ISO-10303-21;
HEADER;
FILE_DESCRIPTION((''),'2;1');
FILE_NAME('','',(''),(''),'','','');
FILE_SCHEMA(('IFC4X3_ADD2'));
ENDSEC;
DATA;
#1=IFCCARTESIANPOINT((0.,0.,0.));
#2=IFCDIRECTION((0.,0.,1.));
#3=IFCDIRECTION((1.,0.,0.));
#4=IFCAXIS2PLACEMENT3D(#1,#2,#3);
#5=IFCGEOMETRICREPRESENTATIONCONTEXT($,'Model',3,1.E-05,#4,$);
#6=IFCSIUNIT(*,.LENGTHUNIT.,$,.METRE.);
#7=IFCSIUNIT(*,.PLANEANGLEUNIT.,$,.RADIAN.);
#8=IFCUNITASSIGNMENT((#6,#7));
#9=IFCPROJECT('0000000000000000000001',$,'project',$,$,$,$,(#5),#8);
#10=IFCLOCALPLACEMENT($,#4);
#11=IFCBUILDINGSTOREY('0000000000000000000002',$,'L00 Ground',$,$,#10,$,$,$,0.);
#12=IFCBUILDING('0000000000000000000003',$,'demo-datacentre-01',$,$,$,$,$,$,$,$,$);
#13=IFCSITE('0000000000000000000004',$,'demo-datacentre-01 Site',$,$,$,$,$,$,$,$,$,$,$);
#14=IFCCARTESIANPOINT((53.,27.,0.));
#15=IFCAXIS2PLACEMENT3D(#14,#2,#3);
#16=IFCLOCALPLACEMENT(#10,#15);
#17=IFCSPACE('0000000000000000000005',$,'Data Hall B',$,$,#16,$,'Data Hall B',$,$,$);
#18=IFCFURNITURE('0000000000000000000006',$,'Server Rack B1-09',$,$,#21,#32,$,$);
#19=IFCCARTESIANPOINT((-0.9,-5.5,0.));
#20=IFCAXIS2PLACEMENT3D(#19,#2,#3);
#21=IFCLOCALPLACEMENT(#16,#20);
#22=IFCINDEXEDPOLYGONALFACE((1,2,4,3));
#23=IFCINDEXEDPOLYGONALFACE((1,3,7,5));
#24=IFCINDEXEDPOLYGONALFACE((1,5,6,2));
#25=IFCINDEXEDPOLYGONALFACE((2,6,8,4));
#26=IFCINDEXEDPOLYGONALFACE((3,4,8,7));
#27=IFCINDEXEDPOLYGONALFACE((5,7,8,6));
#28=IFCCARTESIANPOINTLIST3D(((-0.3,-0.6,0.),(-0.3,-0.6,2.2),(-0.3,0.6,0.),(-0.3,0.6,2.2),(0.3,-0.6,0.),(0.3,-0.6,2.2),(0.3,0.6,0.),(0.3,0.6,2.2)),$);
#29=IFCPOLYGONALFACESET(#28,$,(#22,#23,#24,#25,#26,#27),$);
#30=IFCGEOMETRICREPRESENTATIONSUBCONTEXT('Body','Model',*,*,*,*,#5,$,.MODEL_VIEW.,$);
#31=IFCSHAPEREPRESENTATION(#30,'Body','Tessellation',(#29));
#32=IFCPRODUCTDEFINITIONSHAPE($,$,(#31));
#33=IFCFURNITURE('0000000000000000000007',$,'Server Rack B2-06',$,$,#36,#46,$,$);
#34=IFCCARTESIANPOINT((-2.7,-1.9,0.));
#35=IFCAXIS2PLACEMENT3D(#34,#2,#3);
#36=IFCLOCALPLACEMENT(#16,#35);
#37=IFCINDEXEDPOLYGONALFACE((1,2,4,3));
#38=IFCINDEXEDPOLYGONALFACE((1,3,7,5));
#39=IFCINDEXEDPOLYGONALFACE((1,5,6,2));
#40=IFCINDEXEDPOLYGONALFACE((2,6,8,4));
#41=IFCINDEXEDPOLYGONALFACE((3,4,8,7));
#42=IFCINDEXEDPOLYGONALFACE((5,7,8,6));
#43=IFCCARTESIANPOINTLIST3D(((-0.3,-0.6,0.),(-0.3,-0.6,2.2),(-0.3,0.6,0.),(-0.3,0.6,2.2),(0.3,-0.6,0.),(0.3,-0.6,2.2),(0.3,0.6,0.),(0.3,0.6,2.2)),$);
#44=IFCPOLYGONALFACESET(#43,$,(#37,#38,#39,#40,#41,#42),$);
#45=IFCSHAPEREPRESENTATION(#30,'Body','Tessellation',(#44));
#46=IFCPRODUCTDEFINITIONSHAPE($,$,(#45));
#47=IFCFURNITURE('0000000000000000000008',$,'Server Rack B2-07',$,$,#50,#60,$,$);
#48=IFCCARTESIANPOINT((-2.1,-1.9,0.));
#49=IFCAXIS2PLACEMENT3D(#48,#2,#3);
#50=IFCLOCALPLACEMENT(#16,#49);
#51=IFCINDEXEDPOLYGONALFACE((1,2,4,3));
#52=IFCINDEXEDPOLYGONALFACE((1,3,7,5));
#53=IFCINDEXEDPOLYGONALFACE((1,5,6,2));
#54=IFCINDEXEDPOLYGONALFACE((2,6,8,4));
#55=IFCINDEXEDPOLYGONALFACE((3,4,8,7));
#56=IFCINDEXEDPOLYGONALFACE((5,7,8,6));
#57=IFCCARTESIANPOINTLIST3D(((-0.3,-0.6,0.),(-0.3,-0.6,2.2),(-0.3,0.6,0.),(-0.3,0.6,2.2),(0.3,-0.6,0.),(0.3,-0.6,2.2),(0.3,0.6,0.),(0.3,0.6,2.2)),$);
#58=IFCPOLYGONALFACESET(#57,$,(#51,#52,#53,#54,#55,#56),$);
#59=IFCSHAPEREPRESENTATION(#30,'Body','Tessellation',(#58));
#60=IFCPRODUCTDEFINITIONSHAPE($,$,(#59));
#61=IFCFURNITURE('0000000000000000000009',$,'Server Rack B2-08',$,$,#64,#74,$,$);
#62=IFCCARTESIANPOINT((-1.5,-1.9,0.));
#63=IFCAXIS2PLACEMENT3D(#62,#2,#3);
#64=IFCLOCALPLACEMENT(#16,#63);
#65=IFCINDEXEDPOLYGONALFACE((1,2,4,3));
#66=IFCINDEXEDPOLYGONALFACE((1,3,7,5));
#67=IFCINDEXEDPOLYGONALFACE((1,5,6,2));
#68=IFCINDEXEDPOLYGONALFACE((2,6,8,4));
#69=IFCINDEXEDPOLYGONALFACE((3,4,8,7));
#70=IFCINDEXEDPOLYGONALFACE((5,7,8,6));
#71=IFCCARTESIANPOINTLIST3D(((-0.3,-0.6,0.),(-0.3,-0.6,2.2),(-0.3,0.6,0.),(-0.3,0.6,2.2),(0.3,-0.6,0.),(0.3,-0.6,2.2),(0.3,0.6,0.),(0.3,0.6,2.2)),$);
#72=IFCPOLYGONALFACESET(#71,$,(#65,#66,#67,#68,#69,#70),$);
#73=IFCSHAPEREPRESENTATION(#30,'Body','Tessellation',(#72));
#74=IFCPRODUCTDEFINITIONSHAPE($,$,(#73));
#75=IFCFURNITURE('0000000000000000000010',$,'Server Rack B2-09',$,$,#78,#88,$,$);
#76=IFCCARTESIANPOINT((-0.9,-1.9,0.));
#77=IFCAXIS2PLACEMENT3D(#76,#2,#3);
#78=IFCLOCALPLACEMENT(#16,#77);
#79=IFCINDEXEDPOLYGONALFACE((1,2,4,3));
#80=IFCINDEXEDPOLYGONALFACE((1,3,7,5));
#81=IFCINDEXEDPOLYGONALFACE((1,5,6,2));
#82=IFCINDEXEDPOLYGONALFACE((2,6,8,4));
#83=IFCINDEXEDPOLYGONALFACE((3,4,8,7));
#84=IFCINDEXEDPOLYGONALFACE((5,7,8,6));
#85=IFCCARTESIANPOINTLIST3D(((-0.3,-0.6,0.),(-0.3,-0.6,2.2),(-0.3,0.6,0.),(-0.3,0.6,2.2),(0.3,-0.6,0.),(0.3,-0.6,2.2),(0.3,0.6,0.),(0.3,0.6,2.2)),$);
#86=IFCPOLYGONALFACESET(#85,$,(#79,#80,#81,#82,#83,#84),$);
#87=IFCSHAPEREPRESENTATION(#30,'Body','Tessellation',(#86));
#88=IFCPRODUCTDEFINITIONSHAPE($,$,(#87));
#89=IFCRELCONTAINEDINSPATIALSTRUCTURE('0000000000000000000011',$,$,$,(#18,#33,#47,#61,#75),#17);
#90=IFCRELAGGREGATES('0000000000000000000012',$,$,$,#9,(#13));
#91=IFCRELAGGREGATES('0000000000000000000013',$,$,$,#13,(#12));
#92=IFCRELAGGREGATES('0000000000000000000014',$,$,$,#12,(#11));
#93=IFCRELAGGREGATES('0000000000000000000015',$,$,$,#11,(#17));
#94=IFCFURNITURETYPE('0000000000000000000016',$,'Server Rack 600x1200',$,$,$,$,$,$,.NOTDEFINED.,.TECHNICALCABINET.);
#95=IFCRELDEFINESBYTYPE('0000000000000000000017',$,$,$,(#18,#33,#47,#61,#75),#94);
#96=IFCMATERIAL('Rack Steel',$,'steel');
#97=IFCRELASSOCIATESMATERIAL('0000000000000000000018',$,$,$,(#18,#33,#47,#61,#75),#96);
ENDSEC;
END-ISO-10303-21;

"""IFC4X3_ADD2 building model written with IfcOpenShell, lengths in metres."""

from ifc_helpers import new_model, si_unit, frame, origin_with_axes, place, context, subcontext, project, spatial, rectangle, extrude, material, type_object, element, save


model = new_model("IFC4X3_ADD2")

# Units and contexts
model_context = context("Model", 3, precision=1e-05, world=origin_with_axes())
body_context = subcontext(model_context, "Body", "Model", "MODEL_VIEW")
ifc_project = project(units=[si_unit("LENGTHUNIT", "METRE"), si_unit("PLANEANGLEUNIT", "RADIAN")], contexts=[model_context])

# Site, building, storey
site = spatial("IfcSite", under=ifc_project, Name="demo-datacentre-01 Site")
building = spatial("IfcBuilding", under=site, Name="demo-datacentre-01")
storey_placement = place(None, origin_with_axes())
storey = spatial("IfcBuildingStorey", under=building, at=storey_placement, Name="L00 Ground", Elevation=0.0)

# Shared definitions
space_placement = place(storey_placement, frame((53.0, 27.0, 0.0), z_axis=(0.0, 0.0, 1.0), x_axis=(1.0, 0.0, 0.0)))
space = spatial("IfcSpace", under=storey, at=space_placement, Name="Data Hall B", LongName="Data Hall B")

# Furniture
ifc_material_1 = material(Name="Rack Steel", Category="steel")
furniture_type = type_object("IfcFurnitureType", Name="Server Rack 600x1200", AssemblyPlace="NOTDEFINED", PredefinedType="TECHNICALCABINET")
for number, where, z_axis, x_axis, name in (
    (1, (-0.9, -5.5, 0.0), (0.0, 0.0, 1.0), (1.0, 0.0, 0.0), "Server Rack B1-09"),
    (2, (-2.7, -1.9, 0.0), (0.0, 0.0, 1.0), (1.0, 0.0, 0.0), "Server Rack B2-06"),
    (3, (-2.1, -1.9, 0.0), (0.0, 0.0, 1.0), (1.0, 0.0, 0.0), "Server Rack B2-07"),
    (4, (-1.5, -1.9, 0.0), (0.0, 0.0, 1.0), (1.0, 0.0, 0.0), "Server Rack B2-08"),
    (5, (-0.9, -1.9, 0.0), (0.0, 0.0, 1.0), (1.0, 0.0, 0.0), "Server Rack B2-09"),
):
    element("IfcFurniture", number, at=place(space_placement, frame(where, z_axis=z_axis, x_axis=x_axis)), inside=space, type_object=furniture_type, material=ifc_material_1, Name=name, context=body_context, shape_type="SweptSolid", body=[
        extrude(rectangle(XDim=0.6, YDim=1.2), origin_with_axes(), (0.0, 0.0, 1.0), 2.2),
    ])

save(model, "model.ifc")
